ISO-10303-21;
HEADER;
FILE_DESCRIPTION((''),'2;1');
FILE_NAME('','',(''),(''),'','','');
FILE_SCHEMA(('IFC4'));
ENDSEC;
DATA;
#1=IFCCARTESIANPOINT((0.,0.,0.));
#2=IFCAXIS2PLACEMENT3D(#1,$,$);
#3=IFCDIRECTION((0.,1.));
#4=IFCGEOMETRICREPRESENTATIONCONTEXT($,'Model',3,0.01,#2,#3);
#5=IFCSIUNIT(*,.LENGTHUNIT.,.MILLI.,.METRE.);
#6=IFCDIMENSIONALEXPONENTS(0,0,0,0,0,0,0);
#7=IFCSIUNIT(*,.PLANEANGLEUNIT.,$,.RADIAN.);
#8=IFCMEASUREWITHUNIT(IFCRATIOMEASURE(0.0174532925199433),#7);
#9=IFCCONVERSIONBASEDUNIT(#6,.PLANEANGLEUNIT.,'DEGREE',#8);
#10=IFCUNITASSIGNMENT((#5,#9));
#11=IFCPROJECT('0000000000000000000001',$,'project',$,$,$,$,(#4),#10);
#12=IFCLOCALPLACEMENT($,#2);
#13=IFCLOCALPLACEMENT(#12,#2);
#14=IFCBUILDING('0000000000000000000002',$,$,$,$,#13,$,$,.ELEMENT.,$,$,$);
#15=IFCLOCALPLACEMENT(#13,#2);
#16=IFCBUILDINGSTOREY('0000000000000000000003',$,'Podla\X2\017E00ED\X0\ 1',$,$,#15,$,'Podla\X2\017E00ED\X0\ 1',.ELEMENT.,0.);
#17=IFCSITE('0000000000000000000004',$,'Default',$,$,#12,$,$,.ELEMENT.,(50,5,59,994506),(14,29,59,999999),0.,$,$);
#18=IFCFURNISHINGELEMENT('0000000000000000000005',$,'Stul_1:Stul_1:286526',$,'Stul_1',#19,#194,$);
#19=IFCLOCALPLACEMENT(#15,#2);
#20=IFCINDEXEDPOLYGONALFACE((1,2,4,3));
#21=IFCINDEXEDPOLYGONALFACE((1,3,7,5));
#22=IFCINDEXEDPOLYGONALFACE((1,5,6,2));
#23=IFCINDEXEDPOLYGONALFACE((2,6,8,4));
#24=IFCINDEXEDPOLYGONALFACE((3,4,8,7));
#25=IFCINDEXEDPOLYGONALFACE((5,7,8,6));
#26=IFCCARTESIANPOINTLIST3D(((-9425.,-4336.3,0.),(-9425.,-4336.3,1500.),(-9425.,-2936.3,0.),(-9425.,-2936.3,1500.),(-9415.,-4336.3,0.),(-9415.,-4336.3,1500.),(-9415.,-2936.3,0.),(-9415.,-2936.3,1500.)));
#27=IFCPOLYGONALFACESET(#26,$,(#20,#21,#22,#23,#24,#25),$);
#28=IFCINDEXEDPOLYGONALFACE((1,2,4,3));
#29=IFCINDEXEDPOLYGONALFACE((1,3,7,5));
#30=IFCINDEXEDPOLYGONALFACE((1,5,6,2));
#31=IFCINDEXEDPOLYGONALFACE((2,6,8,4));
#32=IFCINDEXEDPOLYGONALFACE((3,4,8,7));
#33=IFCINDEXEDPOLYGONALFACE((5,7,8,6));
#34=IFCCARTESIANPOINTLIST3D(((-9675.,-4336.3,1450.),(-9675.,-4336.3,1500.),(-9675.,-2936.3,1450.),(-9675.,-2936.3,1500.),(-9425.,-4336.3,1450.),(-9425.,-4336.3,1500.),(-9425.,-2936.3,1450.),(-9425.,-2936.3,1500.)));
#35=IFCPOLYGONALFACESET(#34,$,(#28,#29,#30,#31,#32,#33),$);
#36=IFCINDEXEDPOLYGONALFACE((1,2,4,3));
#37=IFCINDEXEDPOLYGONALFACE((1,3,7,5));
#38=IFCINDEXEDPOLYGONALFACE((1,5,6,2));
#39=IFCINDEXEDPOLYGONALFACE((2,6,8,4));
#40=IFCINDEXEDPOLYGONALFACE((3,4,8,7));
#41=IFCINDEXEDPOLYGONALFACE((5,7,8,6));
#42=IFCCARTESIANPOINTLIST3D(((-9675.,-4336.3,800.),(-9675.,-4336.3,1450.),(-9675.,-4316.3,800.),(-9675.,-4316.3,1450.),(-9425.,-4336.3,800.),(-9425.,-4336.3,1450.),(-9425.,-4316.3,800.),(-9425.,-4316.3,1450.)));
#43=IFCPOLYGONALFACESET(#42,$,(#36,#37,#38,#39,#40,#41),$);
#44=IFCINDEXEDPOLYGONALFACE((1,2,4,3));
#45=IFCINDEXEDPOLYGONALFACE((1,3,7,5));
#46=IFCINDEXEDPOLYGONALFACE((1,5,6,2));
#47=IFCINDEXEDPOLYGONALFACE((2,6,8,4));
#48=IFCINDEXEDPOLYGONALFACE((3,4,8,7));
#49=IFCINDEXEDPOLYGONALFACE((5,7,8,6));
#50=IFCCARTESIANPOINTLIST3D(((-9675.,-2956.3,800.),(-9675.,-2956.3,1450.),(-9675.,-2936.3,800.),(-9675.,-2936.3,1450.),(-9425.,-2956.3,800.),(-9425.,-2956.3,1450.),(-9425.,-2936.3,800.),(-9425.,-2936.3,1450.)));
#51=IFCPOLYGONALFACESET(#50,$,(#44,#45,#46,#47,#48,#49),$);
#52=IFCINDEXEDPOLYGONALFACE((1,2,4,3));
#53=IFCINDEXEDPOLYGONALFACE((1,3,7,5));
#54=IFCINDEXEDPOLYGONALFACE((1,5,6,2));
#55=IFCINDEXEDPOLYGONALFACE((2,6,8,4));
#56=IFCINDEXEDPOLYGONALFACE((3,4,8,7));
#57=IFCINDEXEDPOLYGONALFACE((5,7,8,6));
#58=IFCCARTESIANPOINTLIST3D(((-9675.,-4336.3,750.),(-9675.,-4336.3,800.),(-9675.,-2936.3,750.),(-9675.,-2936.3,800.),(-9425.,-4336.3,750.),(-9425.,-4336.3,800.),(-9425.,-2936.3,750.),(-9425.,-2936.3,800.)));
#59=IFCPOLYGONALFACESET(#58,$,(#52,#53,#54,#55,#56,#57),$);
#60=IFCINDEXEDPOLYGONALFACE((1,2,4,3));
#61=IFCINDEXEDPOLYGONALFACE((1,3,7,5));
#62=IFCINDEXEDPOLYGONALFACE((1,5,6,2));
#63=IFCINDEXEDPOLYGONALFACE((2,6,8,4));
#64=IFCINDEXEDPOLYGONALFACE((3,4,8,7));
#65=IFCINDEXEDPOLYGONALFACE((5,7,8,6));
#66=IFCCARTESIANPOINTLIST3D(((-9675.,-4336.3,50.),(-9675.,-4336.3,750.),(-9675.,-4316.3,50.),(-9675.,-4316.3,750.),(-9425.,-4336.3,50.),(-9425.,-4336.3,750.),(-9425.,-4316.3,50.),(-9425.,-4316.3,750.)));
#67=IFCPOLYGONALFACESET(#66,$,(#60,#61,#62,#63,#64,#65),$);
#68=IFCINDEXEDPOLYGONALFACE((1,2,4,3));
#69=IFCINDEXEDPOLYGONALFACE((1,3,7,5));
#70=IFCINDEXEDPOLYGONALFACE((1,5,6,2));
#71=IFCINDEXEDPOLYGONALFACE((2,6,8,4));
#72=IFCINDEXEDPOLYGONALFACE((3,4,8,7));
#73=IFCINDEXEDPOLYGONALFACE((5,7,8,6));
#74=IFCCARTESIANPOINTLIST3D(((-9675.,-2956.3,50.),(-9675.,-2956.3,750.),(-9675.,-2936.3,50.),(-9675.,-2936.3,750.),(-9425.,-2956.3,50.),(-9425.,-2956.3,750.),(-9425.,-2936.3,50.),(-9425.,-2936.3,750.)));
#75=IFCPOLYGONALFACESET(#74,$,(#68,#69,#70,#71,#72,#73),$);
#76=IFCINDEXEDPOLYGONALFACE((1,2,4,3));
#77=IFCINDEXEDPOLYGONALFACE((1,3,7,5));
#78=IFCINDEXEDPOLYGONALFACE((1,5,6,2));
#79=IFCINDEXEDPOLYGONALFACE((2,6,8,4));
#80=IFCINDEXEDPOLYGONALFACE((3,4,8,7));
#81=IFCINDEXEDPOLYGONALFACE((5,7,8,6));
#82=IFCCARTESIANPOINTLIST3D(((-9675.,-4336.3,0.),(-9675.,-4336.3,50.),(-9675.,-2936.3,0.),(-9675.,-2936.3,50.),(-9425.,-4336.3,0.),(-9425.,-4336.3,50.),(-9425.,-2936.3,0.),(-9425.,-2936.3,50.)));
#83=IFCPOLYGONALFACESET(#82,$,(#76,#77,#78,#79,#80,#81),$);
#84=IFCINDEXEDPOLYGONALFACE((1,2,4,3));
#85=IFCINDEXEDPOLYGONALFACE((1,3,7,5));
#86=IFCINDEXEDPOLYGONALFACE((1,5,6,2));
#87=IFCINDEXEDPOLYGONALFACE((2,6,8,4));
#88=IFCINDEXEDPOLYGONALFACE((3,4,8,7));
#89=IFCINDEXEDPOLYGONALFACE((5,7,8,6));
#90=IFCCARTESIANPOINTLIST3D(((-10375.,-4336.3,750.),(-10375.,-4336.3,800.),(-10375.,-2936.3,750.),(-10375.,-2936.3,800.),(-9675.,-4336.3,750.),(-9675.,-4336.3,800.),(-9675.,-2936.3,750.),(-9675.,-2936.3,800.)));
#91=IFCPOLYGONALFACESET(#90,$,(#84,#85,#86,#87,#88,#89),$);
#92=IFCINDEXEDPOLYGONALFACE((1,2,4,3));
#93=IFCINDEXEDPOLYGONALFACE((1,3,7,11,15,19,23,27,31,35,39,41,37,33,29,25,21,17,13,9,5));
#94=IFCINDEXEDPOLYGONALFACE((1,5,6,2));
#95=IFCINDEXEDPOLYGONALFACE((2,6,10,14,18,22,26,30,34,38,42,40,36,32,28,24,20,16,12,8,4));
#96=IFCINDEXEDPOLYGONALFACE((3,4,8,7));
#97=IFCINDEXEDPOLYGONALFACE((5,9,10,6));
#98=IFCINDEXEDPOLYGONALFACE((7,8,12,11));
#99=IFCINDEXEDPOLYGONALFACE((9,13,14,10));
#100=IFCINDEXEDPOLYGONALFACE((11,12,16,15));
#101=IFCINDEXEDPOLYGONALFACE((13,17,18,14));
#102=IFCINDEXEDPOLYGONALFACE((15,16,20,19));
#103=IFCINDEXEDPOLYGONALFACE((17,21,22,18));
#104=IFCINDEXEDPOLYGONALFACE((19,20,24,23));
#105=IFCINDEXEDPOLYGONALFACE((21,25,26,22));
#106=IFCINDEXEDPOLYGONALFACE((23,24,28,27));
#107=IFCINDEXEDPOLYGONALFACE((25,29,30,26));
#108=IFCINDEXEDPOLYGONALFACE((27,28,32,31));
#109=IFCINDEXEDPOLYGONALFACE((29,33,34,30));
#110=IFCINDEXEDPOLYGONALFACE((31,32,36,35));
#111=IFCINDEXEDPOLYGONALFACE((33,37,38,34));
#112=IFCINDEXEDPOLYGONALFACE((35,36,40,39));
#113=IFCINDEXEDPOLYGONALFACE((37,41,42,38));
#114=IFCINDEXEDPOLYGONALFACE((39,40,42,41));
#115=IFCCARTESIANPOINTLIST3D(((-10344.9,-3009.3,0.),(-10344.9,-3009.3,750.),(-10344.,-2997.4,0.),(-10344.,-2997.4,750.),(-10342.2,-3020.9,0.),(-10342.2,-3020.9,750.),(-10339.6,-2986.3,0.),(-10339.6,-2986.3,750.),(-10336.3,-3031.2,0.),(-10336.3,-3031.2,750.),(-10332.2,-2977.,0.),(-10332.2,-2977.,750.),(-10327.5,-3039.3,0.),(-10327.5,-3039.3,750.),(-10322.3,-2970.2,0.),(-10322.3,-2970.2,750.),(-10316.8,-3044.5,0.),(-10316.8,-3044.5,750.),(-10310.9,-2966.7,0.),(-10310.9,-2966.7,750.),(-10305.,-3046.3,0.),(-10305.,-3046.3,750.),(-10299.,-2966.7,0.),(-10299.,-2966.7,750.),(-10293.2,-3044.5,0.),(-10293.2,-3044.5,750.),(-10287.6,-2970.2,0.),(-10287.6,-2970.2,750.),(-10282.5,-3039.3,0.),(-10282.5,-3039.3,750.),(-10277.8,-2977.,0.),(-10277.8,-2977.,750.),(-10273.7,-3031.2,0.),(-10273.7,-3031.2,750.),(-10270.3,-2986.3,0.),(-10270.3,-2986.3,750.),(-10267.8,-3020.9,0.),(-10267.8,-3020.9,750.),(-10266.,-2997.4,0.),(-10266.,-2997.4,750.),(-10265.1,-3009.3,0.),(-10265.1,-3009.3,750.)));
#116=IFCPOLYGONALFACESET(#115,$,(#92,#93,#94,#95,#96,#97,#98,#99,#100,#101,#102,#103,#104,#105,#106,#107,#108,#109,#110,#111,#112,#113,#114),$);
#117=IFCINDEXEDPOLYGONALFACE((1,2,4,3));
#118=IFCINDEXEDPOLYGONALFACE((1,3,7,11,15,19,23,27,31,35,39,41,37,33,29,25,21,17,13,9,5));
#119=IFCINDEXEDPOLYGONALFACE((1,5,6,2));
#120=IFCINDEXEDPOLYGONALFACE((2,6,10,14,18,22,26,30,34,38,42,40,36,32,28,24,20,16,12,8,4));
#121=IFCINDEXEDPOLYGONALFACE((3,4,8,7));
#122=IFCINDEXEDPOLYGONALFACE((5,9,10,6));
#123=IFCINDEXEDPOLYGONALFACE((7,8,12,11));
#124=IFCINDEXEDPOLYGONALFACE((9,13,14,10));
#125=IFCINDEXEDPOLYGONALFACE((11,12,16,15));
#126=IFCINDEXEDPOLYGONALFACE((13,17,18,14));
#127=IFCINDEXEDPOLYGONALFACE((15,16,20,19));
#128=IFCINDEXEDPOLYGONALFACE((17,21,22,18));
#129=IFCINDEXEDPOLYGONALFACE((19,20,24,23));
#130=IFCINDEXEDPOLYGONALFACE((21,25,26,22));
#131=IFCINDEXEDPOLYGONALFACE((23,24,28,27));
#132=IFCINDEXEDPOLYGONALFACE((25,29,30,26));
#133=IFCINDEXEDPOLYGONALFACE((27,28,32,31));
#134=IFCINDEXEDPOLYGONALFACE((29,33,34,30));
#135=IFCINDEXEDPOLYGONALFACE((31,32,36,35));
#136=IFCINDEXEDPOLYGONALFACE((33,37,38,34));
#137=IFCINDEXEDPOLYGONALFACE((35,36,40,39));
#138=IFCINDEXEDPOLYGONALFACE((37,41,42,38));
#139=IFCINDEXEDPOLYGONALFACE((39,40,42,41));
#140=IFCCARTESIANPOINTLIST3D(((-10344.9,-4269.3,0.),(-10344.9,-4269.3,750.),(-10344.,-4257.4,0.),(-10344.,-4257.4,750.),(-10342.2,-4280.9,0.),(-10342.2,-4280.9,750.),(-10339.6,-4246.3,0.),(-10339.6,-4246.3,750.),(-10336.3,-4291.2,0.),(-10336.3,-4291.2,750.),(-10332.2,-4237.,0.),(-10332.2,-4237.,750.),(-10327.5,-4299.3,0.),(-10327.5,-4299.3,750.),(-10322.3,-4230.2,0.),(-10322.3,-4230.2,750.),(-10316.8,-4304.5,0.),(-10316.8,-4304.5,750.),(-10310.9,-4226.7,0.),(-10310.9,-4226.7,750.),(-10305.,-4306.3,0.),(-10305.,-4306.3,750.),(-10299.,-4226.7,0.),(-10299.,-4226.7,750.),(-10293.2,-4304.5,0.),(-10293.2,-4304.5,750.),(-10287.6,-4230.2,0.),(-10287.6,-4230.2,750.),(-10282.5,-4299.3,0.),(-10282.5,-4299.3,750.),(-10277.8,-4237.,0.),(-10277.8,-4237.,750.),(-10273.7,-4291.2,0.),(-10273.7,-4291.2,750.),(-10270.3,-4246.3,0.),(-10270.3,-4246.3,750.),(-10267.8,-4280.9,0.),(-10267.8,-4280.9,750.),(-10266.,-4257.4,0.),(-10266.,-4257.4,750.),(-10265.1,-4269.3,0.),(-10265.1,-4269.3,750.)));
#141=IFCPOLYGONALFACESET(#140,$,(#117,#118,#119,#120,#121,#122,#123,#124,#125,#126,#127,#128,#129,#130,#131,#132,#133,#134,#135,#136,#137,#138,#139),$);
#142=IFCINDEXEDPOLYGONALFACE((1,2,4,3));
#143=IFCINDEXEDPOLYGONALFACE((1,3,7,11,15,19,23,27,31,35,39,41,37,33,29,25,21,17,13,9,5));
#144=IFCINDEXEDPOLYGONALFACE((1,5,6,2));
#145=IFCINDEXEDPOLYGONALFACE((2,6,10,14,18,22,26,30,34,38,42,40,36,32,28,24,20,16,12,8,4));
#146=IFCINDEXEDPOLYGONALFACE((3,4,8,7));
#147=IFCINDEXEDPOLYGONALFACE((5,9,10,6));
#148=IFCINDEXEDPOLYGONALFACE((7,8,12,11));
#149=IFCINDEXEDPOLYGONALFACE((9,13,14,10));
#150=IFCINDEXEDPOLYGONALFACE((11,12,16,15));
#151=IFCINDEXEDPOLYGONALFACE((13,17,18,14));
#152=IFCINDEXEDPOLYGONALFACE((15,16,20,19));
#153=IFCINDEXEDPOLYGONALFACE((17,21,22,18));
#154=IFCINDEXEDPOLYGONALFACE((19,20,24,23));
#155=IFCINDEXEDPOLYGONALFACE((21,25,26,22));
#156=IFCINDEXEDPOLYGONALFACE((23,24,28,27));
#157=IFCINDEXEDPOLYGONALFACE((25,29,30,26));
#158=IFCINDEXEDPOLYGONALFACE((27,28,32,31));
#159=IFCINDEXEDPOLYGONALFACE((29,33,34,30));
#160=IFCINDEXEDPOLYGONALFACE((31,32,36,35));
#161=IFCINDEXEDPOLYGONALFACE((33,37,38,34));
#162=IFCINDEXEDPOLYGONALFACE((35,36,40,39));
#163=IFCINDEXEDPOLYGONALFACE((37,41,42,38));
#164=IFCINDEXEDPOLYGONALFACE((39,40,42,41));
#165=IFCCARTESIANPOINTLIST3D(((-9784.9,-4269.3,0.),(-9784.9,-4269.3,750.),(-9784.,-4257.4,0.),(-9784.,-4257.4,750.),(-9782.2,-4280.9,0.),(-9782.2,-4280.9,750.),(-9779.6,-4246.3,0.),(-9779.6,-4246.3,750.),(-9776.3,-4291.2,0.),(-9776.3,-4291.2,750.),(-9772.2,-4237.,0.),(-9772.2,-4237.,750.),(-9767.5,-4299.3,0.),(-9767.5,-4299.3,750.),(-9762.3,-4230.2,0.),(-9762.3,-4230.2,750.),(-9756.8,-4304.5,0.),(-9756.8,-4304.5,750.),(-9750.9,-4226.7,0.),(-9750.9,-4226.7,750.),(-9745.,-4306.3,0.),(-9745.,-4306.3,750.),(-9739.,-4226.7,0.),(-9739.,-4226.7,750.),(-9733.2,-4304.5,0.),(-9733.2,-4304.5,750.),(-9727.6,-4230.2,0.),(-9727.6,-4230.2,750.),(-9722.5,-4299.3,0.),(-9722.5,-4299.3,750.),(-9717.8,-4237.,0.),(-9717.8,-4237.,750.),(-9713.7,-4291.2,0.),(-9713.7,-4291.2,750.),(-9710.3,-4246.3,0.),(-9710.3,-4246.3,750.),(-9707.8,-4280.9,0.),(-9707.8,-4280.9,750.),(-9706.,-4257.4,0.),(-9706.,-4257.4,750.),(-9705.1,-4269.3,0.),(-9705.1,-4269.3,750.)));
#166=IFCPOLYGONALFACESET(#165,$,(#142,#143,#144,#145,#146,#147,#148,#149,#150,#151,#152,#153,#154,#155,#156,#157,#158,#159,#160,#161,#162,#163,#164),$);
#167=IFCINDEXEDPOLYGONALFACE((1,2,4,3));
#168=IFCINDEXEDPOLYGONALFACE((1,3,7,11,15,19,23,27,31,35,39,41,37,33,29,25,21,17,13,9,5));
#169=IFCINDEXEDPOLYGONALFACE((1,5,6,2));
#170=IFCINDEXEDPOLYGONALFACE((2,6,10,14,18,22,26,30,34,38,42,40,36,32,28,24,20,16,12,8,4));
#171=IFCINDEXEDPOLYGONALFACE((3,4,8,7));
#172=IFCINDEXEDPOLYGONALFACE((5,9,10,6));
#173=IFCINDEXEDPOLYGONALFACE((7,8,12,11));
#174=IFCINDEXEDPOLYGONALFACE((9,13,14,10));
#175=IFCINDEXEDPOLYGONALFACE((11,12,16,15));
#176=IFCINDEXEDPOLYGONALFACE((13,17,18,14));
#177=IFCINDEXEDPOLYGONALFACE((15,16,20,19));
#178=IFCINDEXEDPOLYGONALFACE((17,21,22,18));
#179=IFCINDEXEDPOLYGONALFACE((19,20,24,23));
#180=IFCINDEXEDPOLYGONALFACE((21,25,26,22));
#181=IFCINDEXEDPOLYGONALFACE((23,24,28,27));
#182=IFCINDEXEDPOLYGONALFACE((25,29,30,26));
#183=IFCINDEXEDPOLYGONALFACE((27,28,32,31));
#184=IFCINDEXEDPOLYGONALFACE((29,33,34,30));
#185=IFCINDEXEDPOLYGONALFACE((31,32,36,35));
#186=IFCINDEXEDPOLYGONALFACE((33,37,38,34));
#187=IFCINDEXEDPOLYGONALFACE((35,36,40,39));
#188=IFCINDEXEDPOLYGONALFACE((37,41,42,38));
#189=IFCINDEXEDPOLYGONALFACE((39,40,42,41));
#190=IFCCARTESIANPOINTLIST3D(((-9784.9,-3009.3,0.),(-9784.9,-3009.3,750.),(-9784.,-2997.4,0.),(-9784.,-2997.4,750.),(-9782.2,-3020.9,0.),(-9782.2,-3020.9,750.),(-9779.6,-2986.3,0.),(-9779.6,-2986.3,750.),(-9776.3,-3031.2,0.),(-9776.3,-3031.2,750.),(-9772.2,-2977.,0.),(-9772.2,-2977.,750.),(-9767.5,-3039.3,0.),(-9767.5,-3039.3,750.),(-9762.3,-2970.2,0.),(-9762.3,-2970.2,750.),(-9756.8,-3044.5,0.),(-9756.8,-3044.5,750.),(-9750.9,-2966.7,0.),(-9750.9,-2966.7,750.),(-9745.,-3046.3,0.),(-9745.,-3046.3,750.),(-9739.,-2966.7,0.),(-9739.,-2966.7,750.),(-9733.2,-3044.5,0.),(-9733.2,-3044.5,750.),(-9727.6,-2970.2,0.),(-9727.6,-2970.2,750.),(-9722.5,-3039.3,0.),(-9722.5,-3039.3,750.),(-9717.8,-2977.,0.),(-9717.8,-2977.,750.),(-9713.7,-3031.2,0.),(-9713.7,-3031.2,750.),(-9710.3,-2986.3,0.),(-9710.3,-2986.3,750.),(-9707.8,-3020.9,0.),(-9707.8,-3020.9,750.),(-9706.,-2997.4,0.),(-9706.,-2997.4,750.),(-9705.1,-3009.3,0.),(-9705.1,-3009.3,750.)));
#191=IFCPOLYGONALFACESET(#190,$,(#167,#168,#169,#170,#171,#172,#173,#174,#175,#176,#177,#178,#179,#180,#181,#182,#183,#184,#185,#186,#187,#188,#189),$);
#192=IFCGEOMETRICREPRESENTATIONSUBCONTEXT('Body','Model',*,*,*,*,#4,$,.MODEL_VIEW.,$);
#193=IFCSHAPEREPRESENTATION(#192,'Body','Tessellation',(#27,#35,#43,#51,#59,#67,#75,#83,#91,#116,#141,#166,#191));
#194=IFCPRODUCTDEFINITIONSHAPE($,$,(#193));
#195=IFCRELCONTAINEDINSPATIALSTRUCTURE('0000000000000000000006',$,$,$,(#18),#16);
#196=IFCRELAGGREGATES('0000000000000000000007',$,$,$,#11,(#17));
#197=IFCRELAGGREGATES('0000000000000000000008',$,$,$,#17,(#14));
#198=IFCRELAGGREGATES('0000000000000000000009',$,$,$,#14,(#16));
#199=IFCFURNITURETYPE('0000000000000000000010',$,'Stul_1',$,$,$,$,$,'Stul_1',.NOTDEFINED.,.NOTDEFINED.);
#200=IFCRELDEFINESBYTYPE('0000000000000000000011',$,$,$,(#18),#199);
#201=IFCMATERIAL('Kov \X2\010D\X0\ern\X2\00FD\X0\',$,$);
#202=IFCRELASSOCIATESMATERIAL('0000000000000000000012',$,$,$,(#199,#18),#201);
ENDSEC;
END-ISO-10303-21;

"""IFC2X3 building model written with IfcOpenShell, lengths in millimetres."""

from ifc_helpers import new_model, entity, si_unit, converted_unit, direction, frame, frame_2d, origin, origin_2d_with_axis, place, context, subcontext, project, spatial, rectangle, circle, extrude, source, transform, mapped, material, type_object, type_shapes, element, save


model = new_model("IFC2X3")

# Units and contexts
model_context = context("Model", 3, precision=0.01, world=origin(), true_north=direction((0.0, 1.0)))
body_context = subcontext(model_context, "Body", "Model", "MODEL_VIEW")
ifc_project = project(units=[si_unit("LENGTHUNIT", "METRE", prefix="MILLI"), converted_unit("PLANEANGLEUNIT", "DEGREE", entity("IfcRatioMeasure", 0.0174532925199433), si_unit("PLANEANGLEUNIT", "RADIAN"), dimensions=[0, 0, 0, 0, 0, 0, 0])], contexts=[model_context])

# Site, building, storey
site_placement = place(None, origin())
site = spatial("IfcSite", under=ifc_project, at=site_placement, Name="Default", CompositionType="ELEMENT", RefLatitude=(50, 5, 59, 994506), RefLongitude=(14, 29, 59, 999999), RefElevation=0.0)
building_placement = place(site_placement, origin())
building = spatial("IfcBuilding", under=site, at=building_placement, CompositionType="ELEMENT")
storey_placement = place(building_placement, origin())
storey = spatial("IfcBuildingStorey", under=building, at=storey_placement, Name="Podlaží 1", LongName="Podlaží 1", CompositionType="ELEMENT", Elevation=0.0)

# Furnishing element
ifc_material_1 = material(Name="Kov černý")
furniture_type = type_object("IfcFurnitureType", Name="Stul_1", ElementType="Stul_1", material=ifc_material_1)
shared_shape_1 = source(origin(), body_context, "Body", "SweptSolid", [
    extrude(rectangle(XDim=1400.0, YDim=10.0, at=origin_2d_with_axis()), frame((0.0, 605.0, 0.0), z_axis=(0.0, 0.0, 1.0), x_axis=(-1.0, 0.0, 0.0)), (0.0, 0.0, 1.0), 1500.0),
    extrude(rectangle(XDim=1400.0, YDim=250.0, at=frame_2d((0.0, 0.0), x_axis=(1.0, 0.0))), frame((0.0, 475.0, 1450.0), z_axis=(0.0, 0.0, 1.0), x_axis=(-1.0, 0.0, 0.0)), (0.0, 0.0, 1.0), 50.0),
    extrude(rectangle(XDim=20.0, YDim=250.0, at=origin_2d_with_axis()), frame((690.0, 475.0, 800.0), z_axis=(0.0, 0.0, 1.0), x_axis=(-1.0, 0.0, 0.0)), (0.0, 0.0, 1.0), 650.0),
    extrude(rectangle(XDim=20.0, YDim=250.0, at=frame_2d((0.0, 0.0), x_axis=(1.0, 0.0))), frame((-690.0, 475.0, 800.0), z_axis=(0.0, 0.0, 1.0), x_axis=(-1.0, 0.0, 0.0)), (0.0, 0.0, 1.0), 650.0),
    extrude(rectangle(XDim=1400.0, YDim=250.0, at=origin_2d_with_axis()), frame((0.0, 475.0, 750.0), z_axis=(0.0, 0.0, 1.0), x_axis=(-1.0, 0.0, 0.0)), (0.0, 0.0, 1.0), 50.0),
    extrude(rectangle(XDim=20.0, YDim=250.0, at=origin_2d_with_axis()), frame((690.0, 475.0, 50.0), z_axis=(0.0, 0.0, 1.0), x_axis=(-1.0, 0.0, 0.0)), (0.0, 0.0, 1.0), 700.0),
    extrude(rectangle(XDim=20.0, YDim=250.0, at=frame_2d((0.0, 0.0), x_axis=(1.0, 0.0))), frame((-690.0, 475.0, 50.0), z_axis=(0.0, 0.0, 1.0), x_axis=(-1.0, 0.0, 0.0)), (0.0, 0.0, 1.0), 700.0),
    extrude(rectangle(XDim=1400.0, YDim=250.0, at=origin_2d_with_axis()), frame((0.0, 475.0, 0.0), z_axis=(0.0, 0.0, 1.0), x_axis=(-1.0, 0.0, 0.0)), (0.0, 0.0, 1.0), 50.0),
    extrude(rectangle(XDim=1400.0, YDim=700.0, at=origin_2d_with_axis()), frame((0.0, 0.0, 750.0), z_axis=(0.0, 0.0, 1.0), x_axis=(-1.0, 0.0, 0.0)), (0.0, 0.0, 1.0), 50.0),
    extrude(circle(Radius=40.0, at=frame_2d((0.0, 0.0), x_axis=(1.0, 0.0))), frame((-630.0, -280.0, 0.0)), (0.0, 0.0, 1.0), 750.0),
    extrude(circle(Radius=40.0, at=frame_2d((0.0, 0.0), x_axis=(1.0, 0.0))), frame((630.0, -280.0, 0.0)), (0.0, 0.0, 1.0), 750.0),
    extrude(circle(Radius=40.0, at=frame_2d((0.0, 0.0), x_axis=(1.0, 0.0))), frame((630.0, 280.0, 0.0)), (0.0, 0.0, 1.0), 750.0),
    extrude(circle(Radius=40.0, at=frame_2d((0.0, 0.0), x_axis=(1.0, 0.0))), frame((-630.0, 280.0, 0.0)), (0.0, 0.0, 1.0), 750.0),
])
type_shapes(furniture_type, [shared_shape_1])
for number, where, z_axis, x_axis, name in (
    (1, (-10025.0, -3636.3, 0.0), (0.0, 0.0, 1.0), (0.0, -1.0, 0.0), "Stul_1:Stul_1:286526"),
):
    element("IfcFurnishingElement", number, at=place(storey_placement, frame(where, z_axis=z_axis, x_axis=x_axis)), inside=storey, type_object=furniture_type, material=ifc_material_1, Name=name, ObjectType="Stul_1", context=body_context, shape_type="MappedRepresentation", body=[
        mapped(shared_shape_1, transform((0.0, 0.0, 0.0), scale=1.0)),
    ])

save(model, "model.ifc")
